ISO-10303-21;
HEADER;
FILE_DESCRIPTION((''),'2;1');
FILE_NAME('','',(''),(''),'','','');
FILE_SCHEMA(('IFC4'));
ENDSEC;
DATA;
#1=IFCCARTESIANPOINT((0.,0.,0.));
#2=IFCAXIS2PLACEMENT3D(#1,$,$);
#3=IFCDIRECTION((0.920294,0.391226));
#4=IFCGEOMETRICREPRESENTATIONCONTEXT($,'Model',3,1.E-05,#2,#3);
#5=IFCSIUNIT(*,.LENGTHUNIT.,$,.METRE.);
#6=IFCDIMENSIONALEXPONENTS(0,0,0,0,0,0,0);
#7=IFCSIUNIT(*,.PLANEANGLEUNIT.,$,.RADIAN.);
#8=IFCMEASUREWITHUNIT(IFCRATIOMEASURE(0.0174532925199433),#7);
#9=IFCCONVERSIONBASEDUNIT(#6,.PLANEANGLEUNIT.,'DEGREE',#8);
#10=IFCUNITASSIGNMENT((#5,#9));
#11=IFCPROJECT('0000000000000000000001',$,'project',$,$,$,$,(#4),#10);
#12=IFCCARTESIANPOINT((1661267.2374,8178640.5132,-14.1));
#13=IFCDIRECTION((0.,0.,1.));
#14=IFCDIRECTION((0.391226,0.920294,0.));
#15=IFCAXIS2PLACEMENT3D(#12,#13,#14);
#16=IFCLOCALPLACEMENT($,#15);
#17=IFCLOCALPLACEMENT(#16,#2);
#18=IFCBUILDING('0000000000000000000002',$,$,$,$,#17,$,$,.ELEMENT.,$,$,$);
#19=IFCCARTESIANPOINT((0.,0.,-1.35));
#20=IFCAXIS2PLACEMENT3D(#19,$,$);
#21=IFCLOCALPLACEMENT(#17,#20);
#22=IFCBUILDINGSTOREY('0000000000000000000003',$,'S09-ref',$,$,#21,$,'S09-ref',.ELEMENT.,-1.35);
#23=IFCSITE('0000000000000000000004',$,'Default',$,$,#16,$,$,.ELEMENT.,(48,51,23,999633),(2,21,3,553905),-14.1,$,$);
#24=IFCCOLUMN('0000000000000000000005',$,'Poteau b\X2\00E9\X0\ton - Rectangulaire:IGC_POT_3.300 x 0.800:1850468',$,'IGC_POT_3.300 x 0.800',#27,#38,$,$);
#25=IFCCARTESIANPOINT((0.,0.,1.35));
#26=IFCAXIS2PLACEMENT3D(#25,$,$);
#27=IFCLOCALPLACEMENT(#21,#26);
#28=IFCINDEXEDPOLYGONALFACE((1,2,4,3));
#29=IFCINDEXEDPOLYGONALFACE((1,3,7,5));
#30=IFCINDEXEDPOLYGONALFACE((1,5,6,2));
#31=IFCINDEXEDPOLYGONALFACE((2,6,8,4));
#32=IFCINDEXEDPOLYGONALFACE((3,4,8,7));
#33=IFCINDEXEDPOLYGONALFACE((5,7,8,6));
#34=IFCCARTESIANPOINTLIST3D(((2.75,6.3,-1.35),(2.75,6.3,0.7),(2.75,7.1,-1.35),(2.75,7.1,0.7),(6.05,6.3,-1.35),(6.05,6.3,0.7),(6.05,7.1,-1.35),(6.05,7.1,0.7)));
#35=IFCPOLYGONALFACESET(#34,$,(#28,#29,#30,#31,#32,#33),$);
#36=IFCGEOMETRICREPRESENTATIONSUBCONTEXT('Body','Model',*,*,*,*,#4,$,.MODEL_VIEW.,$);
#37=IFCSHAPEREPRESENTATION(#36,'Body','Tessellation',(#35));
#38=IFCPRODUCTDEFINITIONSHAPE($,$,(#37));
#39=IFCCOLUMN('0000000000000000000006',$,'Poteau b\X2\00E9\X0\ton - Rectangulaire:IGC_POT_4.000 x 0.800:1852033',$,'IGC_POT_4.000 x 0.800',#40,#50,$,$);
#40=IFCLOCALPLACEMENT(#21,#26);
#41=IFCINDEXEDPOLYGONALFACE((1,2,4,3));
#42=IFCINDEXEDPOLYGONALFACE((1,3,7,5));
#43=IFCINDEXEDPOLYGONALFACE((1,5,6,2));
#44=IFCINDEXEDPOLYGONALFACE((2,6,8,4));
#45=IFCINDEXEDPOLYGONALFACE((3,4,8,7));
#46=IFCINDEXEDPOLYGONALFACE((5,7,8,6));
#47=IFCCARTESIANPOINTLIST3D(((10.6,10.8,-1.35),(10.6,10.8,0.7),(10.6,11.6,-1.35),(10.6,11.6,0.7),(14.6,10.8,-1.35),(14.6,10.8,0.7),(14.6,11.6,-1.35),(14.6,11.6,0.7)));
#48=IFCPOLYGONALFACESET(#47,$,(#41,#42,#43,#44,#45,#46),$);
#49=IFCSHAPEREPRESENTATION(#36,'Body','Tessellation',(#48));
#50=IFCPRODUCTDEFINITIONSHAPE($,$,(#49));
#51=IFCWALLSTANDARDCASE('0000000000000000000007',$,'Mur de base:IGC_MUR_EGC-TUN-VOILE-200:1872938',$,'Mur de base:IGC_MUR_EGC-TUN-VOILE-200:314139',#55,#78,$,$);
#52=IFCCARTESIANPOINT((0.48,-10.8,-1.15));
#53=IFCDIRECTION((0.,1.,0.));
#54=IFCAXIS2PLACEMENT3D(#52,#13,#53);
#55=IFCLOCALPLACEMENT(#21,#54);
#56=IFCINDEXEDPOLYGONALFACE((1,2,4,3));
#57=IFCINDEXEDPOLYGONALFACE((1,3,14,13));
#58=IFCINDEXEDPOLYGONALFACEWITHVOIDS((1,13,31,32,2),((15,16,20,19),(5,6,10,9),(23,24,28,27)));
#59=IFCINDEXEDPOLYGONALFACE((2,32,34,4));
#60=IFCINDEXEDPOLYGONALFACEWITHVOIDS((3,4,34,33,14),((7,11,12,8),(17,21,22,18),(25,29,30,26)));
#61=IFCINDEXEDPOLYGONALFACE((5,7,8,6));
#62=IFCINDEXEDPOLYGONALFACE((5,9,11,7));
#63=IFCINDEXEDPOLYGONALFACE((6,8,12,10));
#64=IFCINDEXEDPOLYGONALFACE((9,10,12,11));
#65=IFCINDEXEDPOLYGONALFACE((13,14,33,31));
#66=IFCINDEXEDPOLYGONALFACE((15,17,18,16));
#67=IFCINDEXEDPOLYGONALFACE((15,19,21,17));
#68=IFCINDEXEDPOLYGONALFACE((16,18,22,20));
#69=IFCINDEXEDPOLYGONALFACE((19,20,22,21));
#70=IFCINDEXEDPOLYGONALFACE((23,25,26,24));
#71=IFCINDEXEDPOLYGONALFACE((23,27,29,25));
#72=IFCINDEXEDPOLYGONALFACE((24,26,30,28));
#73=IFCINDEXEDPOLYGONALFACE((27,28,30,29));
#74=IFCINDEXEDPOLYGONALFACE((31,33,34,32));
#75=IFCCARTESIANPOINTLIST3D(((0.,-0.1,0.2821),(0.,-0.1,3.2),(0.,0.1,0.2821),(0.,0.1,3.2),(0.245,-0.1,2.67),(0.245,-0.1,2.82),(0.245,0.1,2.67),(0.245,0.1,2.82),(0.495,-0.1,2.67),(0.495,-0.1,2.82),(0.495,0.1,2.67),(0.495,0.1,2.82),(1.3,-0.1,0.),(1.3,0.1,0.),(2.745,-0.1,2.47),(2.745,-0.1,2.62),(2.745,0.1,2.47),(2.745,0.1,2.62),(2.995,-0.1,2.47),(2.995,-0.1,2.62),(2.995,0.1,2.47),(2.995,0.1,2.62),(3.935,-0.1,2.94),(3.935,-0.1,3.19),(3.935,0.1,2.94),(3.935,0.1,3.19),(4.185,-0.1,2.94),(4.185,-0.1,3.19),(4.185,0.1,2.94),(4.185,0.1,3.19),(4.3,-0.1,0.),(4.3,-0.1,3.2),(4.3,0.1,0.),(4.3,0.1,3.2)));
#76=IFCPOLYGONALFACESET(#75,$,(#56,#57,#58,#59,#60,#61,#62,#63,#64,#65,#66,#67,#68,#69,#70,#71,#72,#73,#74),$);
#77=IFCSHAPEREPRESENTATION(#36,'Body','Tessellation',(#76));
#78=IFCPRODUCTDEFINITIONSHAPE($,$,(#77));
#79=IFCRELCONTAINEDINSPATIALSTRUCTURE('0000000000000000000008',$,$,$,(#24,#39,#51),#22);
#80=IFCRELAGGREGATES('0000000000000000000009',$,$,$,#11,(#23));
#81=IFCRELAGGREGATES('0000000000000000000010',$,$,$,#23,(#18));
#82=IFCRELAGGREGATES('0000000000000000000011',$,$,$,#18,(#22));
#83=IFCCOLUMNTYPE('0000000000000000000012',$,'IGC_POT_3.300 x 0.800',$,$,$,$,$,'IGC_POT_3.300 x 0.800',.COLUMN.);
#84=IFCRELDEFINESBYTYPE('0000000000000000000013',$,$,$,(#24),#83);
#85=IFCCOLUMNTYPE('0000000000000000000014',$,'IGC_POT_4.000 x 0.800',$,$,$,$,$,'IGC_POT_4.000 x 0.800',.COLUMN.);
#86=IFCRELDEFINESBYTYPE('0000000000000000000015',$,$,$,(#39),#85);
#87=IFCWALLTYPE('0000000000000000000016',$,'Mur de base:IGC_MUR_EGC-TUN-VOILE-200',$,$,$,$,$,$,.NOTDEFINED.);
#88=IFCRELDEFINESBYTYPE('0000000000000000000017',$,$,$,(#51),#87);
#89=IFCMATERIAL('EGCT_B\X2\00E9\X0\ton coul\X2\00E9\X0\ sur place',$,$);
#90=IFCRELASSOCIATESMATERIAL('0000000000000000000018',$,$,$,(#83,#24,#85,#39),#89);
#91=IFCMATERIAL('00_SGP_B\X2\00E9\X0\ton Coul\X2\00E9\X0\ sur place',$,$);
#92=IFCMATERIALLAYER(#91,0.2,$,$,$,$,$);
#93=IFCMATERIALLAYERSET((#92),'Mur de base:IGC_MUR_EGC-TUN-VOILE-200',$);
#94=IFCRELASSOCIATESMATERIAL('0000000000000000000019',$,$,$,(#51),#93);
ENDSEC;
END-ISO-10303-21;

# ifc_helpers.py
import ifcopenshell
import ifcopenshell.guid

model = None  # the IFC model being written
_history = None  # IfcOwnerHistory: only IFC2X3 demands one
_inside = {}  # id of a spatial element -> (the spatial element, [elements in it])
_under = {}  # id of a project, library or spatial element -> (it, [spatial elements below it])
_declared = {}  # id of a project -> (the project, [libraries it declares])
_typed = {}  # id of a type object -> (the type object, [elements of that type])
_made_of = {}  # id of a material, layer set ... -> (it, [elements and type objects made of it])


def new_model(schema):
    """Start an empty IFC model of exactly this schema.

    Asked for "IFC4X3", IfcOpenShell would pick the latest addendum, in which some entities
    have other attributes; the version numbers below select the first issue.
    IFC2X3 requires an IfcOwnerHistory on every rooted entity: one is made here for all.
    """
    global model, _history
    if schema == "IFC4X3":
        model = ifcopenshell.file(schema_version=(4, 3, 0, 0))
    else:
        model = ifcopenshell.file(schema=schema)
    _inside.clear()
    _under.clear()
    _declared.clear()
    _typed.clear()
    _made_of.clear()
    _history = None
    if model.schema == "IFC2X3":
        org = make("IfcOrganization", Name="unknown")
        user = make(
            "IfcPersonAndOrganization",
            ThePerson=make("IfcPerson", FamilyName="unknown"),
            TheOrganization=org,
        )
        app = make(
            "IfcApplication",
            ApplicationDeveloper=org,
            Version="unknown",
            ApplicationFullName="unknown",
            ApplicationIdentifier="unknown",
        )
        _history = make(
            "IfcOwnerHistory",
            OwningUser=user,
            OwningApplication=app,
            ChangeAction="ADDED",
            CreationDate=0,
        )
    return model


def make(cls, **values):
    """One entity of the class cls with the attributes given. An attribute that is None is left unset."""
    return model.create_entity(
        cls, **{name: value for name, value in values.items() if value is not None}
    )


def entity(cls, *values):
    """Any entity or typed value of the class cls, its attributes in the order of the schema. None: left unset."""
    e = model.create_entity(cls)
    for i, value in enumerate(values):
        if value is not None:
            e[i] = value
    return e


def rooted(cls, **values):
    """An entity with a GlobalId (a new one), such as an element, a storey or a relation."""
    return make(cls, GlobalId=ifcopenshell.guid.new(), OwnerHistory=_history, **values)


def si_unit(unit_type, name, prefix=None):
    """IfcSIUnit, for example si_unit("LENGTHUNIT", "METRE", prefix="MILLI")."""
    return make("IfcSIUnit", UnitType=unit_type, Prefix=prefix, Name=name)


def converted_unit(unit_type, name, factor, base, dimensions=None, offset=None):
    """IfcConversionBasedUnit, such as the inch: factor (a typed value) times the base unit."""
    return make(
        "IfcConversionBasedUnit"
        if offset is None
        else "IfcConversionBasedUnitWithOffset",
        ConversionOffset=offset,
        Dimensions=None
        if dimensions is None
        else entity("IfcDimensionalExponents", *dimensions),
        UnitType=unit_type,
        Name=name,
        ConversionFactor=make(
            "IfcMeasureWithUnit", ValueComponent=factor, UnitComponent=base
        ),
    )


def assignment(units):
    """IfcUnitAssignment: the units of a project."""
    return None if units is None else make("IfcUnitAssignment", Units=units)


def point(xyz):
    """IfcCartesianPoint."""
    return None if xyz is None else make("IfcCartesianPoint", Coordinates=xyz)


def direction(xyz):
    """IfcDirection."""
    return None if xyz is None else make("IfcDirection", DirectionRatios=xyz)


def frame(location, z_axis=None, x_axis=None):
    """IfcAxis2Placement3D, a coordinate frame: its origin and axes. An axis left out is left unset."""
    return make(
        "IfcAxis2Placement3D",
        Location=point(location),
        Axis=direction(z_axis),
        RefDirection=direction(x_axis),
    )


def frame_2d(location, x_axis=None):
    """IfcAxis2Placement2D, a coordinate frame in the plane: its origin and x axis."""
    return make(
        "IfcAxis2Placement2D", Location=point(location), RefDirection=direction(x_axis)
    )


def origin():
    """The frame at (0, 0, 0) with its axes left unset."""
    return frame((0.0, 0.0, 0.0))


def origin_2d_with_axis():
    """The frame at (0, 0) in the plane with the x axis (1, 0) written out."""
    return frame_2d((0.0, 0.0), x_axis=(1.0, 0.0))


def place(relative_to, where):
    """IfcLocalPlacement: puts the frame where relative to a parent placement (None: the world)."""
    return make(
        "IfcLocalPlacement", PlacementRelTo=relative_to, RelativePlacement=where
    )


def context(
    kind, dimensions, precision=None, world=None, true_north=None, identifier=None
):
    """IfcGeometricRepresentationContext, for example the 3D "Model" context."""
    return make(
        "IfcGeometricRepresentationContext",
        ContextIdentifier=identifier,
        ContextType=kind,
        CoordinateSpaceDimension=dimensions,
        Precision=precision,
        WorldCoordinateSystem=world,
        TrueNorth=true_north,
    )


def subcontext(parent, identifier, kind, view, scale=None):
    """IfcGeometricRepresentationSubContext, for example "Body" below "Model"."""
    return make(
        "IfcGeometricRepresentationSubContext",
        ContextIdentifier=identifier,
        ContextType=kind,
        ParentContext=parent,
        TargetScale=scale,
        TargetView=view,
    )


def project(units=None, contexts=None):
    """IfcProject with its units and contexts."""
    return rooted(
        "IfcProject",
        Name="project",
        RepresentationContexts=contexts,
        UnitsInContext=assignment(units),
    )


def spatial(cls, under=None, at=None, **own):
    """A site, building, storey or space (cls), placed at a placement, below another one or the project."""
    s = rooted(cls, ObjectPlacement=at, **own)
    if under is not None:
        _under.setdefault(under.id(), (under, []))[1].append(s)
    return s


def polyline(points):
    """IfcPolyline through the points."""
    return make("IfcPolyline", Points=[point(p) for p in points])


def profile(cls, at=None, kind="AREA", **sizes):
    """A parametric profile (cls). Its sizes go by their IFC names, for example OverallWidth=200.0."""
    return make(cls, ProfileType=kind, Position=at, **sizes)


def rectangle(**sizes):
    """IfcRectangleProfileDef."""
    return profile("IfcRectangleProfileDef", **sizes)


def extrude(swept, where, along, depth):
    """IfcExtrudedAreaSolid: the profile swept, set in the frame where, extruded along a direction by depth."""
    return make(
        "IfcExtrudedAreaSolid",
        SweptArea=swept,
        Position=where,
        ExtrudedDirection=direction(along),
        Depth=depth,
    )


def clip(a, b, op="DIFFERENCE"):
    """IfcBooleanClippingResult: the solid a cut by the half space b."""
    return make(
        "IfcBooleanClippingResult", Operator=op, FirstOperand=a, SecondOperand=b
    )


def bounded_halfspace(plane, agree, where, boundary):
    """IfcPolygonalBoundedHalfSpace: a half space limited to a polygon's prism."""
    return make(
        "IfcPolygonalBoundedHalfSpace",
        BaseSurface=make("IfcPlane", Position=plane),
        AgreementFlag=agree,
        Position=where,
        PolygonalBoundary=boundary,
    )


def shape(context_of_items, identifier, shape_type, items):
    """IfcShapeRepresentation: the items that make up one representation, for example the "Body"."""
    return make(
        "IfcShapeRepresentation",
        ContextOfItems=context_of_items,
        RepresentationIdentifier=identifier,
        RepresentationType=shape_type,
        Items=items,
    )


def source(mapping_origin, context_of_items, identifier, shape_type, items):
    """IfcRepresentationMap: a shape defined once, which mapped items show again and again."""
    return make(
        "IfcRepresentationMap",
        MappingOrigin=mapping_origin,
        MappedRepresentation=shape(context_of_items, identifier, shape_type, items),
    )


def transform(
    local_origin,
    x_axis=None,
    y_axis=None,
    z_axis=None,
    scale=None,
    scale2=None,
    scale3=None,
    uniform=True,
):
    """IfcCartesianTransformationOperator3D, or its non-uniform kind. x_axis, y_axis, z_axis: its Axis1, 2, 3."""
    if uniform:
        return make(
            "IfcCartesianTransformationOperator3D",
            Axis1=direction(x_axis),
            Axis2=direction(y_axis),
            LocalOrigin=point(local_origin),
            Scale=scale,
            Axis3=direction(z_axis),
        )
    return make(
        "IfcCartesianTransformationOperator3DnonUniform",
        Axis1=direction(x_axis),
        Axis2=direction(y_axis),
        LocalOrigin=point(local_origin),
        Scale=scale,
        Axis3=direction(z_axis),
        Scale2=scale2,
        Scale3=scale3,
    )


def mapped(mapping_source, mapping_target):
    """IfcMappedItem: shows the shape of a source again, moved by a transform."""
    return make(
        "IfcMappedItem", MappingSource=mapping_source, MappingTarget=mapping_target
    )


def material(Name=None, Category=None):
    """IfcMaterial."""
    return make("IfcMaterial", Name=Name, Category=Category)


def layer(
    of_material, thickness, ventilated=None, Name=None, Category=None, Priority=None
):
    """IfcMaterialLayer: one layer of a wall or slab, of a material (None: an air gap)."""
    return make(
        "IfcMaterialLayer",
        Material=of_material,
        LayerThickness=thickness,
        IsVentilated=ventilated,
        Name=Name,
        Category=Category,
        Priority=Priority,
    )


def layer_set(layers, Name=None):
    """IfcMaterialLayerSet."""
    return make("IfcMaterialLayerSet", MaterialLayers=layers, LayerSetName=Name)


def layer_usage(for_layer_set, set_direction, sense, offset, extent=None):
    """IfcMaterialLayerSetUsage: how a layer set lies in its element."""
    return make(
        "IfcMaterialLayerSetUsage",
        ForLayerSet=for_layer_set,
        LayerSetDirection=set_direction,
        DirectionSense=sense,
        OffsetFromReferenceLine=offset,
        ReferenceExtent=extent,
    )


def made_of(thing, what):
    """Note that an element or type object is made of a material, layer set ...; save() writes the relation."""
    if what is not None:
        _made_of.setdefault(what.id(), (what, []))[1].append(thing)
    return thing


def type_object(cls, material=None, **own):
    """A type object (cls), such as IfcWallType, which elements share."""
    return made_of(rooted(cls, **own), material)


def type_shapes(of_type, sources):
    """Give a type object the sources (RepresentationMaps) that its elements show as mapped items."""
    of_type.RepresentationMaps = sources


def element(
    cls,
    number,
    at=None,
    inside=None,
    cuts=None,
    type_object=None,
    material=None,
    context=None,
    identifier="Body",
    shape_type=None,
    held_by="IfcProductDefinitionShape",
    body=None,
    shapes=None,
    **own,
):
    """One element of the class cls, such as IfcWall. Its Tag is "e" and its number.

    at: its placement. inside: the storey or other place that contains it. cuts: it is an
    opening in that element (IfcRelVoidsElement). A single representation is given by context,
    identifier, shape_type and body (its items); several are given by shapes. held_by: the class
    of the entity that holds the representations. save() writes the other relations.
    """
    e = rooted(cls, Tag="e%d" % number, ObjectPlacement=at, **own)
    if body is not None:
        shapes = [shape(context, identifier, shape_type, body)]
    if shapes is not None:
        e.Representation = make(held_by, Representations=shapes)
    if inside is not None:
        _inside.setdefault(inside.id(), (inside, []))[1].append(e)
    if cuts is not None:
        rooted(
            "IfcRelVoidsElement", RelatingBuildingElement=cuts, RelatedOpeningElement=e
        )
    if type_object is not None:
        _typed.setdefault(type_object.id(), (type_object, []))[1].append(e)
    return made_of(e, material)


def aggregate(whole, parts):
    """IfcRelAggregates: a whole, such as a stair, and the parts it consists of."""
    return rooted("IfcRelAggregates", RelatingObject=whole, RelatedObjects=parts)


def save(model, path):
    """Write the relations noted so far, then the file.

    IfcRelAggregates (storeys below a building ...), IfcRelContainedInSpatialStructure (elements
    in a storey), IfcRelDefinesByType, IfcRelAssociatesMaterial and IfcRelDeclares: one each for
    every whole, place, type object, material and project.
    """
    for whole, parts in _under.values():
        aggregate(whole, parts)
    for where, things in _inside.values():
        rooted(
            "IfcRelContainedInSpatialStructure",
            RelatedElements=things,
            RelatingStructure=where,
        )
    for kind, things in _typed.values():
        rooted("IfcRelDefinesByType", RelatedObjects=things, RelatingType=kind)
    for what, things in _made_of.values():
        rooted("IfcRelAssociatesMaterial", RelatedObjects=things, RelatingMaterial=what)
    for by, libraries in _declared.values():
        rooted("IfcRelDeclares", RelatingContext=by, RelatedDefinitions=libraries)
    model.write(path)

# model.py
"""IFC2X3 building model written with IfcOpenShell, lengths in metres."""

from ifc_helpers import new_model, entity, si_unit, converted_unit, direction, frame, frame_2d, origin, origin_2d_with_axis, place, context, subcontext, project, spatial, polyline, rectangle, extrude, clip, bounded_halfspace, source, transform, mapped, material, layer, layer_set, layer_usage, type_object, type_shapes, element, save


model = new_model("IFC2X3")

# Units and contexts
model_context = context("Model", 3, precision=1e-05, world=origin(), true_north=direction((0.920294, 0.391226)))
body_context = subcontext(model_context, "Body", "Model", "MODEL_VIEW")
ifc_project = project(units=[si_unit("LENGTHUNIT", "METRE"), converted_unit("PLANEANGLEUNIT", "DEGREE", entity("IfcRatioMeasure", 0.0174532925199433), si_unit("PLANEANGLEUNIT", "RADIAN"), dimensions=[0, 0, 0, 0, 0, 0, 0])], contexts=[model_context])

# Site, building, storey
site_placement = place(None, frame((1661267.2374, 8178640.5132, -14.1), z_axis=(0.0, 0.0, 1.0), x_axis=(0.391226, 0.920294, 0.0)))
site = spatial("IfcSite", under=ifc_project, at=site_placement, Name="Default", CompositionType="ELEMENT", RefLatitude=(48, 51, 23, 999633), RefLongitude=(2, 21, 3, 553905), RefElevation=-14.1)
building_placement = place(site_placement, origin())
building = spatial("IfcBuilding", under=site, at=building_placement, CompositionType="ELEMENT")
storey_placement = place(building_placement, frame((0.0, 0.0, -1.35)))
storey = spatial("IfcBuildingStorey", under=building, at=storey_placement, Name="S09-ref", LongName="S09-ref", CompositionType="ELEMENT", Elevation=-1.35)

# Columns
ifc_material_1 = material(Name="EGCT_Béton coulé sur place")
column_type_1 = type_object("IfcColumnType", Name="IGC_POT_3.300 x 0.800", ElementType="IGC_POT_3.300 x 0.800", PredefinedType="COLUMN", material=ifc_material_1)
shared_shape_1 = source(origin(), body_context, "Body", "SweptSolid", [
    extrude(rectangle(XDim=0.8, YDim=3.3, at=frame_2d((0.0, 0.0), x_axis=(1.0, 0.0))), frame((4.4, 6.7, -1.35), z_axis=(0.0, 0.0, 1.0), x_axis=(0.0, -1.0, 0.0)), (0.0, 0.0, 1.0), 2.05),
])
type_shapes(column_type_1, [shared_shape_1])
column_1_placement = place(storey_placement, frame((0.0, 0.0, 1.35)))
element("IfcColumn", 1, at=column_1_placement, inside=storey, type_object=column_type_1, material=ifc_material_1, Name="Poteau béton - Rectangulaire:IGC_POT_3.300 x 0.800:1850468", ObjectType="IGC_POT_3.300 x 0.800", context=body_context, shape_type="MappedRepresentation", body=[
    mapped(shared_shape_1, transform((0.0, 0.0, 0.0), scale=1.0)),
])
column_type_2 = type_object("IfcColumnType", Name="IGC_POT_4.000 x 0.800", ElementType="IGC_POT_4.000 x 0.800", PredefinedType="COLUMN", material=ifc_material_1)
shared_shape_2 = source(origin(), body_context, "Body", "SweptSolid", [
    extrude(rectangle(XDim=0.8, YDim=4.0, at=origin_2d_with_axis()), frame((12.6, 11.2, -1.35), z_axis=(0.0, 0.0, 1.0), x_axis=(0.0, -1.0, 0.0)), (0.0, 0.0, 1.0), 2.05),
])
type_shapes(column_type_2, [shared_shape_2])
column_2_placement = place(storey_placement, frame((0.0, 0.0, 1.35)))
element("IfcColumn", 2, at=column_2_placement, inside=storey, type_object=column_type_2, material=ifc_material_1, Name="Poteau béton - Rectangulaire:IGC_POT_4.000 x 0.800:1852033", ObjectType="IGC_POT_4.000 x 0.800", context=body_context, shape_type="MappedRepresentation", body=[
    mapped(shared_shape_2, transform((0.0, 0.0, 0.0), scale=1.0)),
])

# Wall, openings
ifc_material_2 = material(Name="00_SGP_Béton Coulé sur place")
ifc_layer_1 = layer(ifc_material_2, 0.2)
ifc_layer_set_1 = layer_set([ifc_layer_1], Name="Mur de base:IGC_MUR_EGC-TUN-VOILE-200")
ifc_layer_usage_1 = layer_usage(ifc_layer_set_1, "AXIS2", "POSITIVE", -0.1)
wall_type_1 = type_object("IfcWallType", Name="Mur de base:IGC_MUR_EGC-TUN-VOILE-200", PredefinedType="NOTDEFINED")
wall_1_placement = place(storey_placement, frame((0.48, -10.8, -1.15), z_axis=(0.0, 0.0, 1.0), x_axis=(0.0, 1.0, 0.0)))
wall_1 = element("IfcWallStandardCase", 3, at=wall_1_placement, inside=storey, type_object=wall_type_1, material=ifc_layer_usage_1, Name="Mur de base:IGC_MUR_EGC-TUN-VOILE-200:1872938", ObjectType="Mur de base:IGC_MUR_EGC-TUN-VOILE-200:314139", context=body_context, shape_type="Clipping", body=[
    clip(clip(clip(extrude(rectangle(XDim=4.3, YDim=0.2, at=frame_2d((2.15, 0.0), x_axis=(-1.0, 0.0))), origin(), (0.0, 0.0, 1.0), 3.2), bounded_halfspace(frame((4.3, 0.1, 0.0), z_axis=(0.0, 0.0, 1.0), x_axis=(0.0, 1.0, 0.0)), True, frame((4.3, 0.1, 0.0)), polyline([(0.0, 0.0), (-0.4, 0.0), (-0.6, 0.0), (-2.9999, 0.0), (-2.9999, -0.2), (-0.6, -0.2), (-0.4, -0.2), (0.0, -0.2), (0.0, 0.0)]))), bounded_halfspace(frame((0.0, -0.1, 0.2821), z_axis=(0.21204, 0.0, 0.977261), x_axis=(0.0, 1.0, 0.0)), True, frame((0.0, -0.1, 0.2821)), polyline([(0.0, 0.0), (1.3, 0.0), (1.3, 0.2), (0.0, 0.2), (0.0, 0.0)]))), bounded_halfspace(frame((0.0, -0.1, 3.2), z_axis=(0.0, 0.0, -1.0), x_axis=(0.0, 1.0, 0.0)), True, frame((0.0, -0.1, 3.2)), polyline([(0.0, 0.0), (3.7, 0.0), (3.9, 0.0), (4.3, 0.0), (4.3, 0.2), (3.9, 0.2), (3.7, 0.2), (0.0, 0.2), (0.0, 0.0)]))),
])
opening_1_placement = place(wall_1_placement, origin())
element("IfcOpeningElement", 4, at=opening_1_placement, cuts=wall_1, ObjectType="Opening", context=body_context, shape_type="SweptSolid", body=[
    extrude(rectangle(XDim=0.15, YDim=0.25, at=frame_2d((0.0, 0.0), x_axis=(0.0, 1.0))), frame((0.37, -1.424, 2.745), z_axis=(0.0, 1.0, 0.0), x_axis=(1.0, 0.0, 0.0)), (0.0, 0.0, 1.0), 3.048),
])
opening_2_placement = place(wall_1_placement, origin())
element("IfcOpeningElement", 5, at=opening_2_placement, cuts=wall_1, ObjectType="Opening", context=body_context, shape_type="SweptSolid", body=[
    extrude(rectangle(XDim=0.15, YDim=0.25, at=frame_2d((0.0, 0.0), x_axis=(0.0, 1.0))), frame((2.87, -1.424, 2.545), z_axis=(0.0, 1.0, 0.0), x_axis=(1.0, 0.0, 0.0)), (0.0, 0.0, 1.0), 3.048),
])
opening_3_placement = place(wall_1_placement, origin())
element("IfcOpeningElement", 6, at=opening_3_placement, cuts=wall_1, ObjectType="Opening", context=body_context, shape_type="SweptSolid", body=[
    extrude(rectangle(XDim=0.25, YDim=0.25, at=origin_2d_with_axis()), frame((4.06, -1.424, 3.065), z_axis=(0.0, 1.0, 0.0), x_axis=(0.0, 0.0, -1.0)), (0.0, 0.0, 1.0), 3.048),
])

save(model, "model.ifc")
